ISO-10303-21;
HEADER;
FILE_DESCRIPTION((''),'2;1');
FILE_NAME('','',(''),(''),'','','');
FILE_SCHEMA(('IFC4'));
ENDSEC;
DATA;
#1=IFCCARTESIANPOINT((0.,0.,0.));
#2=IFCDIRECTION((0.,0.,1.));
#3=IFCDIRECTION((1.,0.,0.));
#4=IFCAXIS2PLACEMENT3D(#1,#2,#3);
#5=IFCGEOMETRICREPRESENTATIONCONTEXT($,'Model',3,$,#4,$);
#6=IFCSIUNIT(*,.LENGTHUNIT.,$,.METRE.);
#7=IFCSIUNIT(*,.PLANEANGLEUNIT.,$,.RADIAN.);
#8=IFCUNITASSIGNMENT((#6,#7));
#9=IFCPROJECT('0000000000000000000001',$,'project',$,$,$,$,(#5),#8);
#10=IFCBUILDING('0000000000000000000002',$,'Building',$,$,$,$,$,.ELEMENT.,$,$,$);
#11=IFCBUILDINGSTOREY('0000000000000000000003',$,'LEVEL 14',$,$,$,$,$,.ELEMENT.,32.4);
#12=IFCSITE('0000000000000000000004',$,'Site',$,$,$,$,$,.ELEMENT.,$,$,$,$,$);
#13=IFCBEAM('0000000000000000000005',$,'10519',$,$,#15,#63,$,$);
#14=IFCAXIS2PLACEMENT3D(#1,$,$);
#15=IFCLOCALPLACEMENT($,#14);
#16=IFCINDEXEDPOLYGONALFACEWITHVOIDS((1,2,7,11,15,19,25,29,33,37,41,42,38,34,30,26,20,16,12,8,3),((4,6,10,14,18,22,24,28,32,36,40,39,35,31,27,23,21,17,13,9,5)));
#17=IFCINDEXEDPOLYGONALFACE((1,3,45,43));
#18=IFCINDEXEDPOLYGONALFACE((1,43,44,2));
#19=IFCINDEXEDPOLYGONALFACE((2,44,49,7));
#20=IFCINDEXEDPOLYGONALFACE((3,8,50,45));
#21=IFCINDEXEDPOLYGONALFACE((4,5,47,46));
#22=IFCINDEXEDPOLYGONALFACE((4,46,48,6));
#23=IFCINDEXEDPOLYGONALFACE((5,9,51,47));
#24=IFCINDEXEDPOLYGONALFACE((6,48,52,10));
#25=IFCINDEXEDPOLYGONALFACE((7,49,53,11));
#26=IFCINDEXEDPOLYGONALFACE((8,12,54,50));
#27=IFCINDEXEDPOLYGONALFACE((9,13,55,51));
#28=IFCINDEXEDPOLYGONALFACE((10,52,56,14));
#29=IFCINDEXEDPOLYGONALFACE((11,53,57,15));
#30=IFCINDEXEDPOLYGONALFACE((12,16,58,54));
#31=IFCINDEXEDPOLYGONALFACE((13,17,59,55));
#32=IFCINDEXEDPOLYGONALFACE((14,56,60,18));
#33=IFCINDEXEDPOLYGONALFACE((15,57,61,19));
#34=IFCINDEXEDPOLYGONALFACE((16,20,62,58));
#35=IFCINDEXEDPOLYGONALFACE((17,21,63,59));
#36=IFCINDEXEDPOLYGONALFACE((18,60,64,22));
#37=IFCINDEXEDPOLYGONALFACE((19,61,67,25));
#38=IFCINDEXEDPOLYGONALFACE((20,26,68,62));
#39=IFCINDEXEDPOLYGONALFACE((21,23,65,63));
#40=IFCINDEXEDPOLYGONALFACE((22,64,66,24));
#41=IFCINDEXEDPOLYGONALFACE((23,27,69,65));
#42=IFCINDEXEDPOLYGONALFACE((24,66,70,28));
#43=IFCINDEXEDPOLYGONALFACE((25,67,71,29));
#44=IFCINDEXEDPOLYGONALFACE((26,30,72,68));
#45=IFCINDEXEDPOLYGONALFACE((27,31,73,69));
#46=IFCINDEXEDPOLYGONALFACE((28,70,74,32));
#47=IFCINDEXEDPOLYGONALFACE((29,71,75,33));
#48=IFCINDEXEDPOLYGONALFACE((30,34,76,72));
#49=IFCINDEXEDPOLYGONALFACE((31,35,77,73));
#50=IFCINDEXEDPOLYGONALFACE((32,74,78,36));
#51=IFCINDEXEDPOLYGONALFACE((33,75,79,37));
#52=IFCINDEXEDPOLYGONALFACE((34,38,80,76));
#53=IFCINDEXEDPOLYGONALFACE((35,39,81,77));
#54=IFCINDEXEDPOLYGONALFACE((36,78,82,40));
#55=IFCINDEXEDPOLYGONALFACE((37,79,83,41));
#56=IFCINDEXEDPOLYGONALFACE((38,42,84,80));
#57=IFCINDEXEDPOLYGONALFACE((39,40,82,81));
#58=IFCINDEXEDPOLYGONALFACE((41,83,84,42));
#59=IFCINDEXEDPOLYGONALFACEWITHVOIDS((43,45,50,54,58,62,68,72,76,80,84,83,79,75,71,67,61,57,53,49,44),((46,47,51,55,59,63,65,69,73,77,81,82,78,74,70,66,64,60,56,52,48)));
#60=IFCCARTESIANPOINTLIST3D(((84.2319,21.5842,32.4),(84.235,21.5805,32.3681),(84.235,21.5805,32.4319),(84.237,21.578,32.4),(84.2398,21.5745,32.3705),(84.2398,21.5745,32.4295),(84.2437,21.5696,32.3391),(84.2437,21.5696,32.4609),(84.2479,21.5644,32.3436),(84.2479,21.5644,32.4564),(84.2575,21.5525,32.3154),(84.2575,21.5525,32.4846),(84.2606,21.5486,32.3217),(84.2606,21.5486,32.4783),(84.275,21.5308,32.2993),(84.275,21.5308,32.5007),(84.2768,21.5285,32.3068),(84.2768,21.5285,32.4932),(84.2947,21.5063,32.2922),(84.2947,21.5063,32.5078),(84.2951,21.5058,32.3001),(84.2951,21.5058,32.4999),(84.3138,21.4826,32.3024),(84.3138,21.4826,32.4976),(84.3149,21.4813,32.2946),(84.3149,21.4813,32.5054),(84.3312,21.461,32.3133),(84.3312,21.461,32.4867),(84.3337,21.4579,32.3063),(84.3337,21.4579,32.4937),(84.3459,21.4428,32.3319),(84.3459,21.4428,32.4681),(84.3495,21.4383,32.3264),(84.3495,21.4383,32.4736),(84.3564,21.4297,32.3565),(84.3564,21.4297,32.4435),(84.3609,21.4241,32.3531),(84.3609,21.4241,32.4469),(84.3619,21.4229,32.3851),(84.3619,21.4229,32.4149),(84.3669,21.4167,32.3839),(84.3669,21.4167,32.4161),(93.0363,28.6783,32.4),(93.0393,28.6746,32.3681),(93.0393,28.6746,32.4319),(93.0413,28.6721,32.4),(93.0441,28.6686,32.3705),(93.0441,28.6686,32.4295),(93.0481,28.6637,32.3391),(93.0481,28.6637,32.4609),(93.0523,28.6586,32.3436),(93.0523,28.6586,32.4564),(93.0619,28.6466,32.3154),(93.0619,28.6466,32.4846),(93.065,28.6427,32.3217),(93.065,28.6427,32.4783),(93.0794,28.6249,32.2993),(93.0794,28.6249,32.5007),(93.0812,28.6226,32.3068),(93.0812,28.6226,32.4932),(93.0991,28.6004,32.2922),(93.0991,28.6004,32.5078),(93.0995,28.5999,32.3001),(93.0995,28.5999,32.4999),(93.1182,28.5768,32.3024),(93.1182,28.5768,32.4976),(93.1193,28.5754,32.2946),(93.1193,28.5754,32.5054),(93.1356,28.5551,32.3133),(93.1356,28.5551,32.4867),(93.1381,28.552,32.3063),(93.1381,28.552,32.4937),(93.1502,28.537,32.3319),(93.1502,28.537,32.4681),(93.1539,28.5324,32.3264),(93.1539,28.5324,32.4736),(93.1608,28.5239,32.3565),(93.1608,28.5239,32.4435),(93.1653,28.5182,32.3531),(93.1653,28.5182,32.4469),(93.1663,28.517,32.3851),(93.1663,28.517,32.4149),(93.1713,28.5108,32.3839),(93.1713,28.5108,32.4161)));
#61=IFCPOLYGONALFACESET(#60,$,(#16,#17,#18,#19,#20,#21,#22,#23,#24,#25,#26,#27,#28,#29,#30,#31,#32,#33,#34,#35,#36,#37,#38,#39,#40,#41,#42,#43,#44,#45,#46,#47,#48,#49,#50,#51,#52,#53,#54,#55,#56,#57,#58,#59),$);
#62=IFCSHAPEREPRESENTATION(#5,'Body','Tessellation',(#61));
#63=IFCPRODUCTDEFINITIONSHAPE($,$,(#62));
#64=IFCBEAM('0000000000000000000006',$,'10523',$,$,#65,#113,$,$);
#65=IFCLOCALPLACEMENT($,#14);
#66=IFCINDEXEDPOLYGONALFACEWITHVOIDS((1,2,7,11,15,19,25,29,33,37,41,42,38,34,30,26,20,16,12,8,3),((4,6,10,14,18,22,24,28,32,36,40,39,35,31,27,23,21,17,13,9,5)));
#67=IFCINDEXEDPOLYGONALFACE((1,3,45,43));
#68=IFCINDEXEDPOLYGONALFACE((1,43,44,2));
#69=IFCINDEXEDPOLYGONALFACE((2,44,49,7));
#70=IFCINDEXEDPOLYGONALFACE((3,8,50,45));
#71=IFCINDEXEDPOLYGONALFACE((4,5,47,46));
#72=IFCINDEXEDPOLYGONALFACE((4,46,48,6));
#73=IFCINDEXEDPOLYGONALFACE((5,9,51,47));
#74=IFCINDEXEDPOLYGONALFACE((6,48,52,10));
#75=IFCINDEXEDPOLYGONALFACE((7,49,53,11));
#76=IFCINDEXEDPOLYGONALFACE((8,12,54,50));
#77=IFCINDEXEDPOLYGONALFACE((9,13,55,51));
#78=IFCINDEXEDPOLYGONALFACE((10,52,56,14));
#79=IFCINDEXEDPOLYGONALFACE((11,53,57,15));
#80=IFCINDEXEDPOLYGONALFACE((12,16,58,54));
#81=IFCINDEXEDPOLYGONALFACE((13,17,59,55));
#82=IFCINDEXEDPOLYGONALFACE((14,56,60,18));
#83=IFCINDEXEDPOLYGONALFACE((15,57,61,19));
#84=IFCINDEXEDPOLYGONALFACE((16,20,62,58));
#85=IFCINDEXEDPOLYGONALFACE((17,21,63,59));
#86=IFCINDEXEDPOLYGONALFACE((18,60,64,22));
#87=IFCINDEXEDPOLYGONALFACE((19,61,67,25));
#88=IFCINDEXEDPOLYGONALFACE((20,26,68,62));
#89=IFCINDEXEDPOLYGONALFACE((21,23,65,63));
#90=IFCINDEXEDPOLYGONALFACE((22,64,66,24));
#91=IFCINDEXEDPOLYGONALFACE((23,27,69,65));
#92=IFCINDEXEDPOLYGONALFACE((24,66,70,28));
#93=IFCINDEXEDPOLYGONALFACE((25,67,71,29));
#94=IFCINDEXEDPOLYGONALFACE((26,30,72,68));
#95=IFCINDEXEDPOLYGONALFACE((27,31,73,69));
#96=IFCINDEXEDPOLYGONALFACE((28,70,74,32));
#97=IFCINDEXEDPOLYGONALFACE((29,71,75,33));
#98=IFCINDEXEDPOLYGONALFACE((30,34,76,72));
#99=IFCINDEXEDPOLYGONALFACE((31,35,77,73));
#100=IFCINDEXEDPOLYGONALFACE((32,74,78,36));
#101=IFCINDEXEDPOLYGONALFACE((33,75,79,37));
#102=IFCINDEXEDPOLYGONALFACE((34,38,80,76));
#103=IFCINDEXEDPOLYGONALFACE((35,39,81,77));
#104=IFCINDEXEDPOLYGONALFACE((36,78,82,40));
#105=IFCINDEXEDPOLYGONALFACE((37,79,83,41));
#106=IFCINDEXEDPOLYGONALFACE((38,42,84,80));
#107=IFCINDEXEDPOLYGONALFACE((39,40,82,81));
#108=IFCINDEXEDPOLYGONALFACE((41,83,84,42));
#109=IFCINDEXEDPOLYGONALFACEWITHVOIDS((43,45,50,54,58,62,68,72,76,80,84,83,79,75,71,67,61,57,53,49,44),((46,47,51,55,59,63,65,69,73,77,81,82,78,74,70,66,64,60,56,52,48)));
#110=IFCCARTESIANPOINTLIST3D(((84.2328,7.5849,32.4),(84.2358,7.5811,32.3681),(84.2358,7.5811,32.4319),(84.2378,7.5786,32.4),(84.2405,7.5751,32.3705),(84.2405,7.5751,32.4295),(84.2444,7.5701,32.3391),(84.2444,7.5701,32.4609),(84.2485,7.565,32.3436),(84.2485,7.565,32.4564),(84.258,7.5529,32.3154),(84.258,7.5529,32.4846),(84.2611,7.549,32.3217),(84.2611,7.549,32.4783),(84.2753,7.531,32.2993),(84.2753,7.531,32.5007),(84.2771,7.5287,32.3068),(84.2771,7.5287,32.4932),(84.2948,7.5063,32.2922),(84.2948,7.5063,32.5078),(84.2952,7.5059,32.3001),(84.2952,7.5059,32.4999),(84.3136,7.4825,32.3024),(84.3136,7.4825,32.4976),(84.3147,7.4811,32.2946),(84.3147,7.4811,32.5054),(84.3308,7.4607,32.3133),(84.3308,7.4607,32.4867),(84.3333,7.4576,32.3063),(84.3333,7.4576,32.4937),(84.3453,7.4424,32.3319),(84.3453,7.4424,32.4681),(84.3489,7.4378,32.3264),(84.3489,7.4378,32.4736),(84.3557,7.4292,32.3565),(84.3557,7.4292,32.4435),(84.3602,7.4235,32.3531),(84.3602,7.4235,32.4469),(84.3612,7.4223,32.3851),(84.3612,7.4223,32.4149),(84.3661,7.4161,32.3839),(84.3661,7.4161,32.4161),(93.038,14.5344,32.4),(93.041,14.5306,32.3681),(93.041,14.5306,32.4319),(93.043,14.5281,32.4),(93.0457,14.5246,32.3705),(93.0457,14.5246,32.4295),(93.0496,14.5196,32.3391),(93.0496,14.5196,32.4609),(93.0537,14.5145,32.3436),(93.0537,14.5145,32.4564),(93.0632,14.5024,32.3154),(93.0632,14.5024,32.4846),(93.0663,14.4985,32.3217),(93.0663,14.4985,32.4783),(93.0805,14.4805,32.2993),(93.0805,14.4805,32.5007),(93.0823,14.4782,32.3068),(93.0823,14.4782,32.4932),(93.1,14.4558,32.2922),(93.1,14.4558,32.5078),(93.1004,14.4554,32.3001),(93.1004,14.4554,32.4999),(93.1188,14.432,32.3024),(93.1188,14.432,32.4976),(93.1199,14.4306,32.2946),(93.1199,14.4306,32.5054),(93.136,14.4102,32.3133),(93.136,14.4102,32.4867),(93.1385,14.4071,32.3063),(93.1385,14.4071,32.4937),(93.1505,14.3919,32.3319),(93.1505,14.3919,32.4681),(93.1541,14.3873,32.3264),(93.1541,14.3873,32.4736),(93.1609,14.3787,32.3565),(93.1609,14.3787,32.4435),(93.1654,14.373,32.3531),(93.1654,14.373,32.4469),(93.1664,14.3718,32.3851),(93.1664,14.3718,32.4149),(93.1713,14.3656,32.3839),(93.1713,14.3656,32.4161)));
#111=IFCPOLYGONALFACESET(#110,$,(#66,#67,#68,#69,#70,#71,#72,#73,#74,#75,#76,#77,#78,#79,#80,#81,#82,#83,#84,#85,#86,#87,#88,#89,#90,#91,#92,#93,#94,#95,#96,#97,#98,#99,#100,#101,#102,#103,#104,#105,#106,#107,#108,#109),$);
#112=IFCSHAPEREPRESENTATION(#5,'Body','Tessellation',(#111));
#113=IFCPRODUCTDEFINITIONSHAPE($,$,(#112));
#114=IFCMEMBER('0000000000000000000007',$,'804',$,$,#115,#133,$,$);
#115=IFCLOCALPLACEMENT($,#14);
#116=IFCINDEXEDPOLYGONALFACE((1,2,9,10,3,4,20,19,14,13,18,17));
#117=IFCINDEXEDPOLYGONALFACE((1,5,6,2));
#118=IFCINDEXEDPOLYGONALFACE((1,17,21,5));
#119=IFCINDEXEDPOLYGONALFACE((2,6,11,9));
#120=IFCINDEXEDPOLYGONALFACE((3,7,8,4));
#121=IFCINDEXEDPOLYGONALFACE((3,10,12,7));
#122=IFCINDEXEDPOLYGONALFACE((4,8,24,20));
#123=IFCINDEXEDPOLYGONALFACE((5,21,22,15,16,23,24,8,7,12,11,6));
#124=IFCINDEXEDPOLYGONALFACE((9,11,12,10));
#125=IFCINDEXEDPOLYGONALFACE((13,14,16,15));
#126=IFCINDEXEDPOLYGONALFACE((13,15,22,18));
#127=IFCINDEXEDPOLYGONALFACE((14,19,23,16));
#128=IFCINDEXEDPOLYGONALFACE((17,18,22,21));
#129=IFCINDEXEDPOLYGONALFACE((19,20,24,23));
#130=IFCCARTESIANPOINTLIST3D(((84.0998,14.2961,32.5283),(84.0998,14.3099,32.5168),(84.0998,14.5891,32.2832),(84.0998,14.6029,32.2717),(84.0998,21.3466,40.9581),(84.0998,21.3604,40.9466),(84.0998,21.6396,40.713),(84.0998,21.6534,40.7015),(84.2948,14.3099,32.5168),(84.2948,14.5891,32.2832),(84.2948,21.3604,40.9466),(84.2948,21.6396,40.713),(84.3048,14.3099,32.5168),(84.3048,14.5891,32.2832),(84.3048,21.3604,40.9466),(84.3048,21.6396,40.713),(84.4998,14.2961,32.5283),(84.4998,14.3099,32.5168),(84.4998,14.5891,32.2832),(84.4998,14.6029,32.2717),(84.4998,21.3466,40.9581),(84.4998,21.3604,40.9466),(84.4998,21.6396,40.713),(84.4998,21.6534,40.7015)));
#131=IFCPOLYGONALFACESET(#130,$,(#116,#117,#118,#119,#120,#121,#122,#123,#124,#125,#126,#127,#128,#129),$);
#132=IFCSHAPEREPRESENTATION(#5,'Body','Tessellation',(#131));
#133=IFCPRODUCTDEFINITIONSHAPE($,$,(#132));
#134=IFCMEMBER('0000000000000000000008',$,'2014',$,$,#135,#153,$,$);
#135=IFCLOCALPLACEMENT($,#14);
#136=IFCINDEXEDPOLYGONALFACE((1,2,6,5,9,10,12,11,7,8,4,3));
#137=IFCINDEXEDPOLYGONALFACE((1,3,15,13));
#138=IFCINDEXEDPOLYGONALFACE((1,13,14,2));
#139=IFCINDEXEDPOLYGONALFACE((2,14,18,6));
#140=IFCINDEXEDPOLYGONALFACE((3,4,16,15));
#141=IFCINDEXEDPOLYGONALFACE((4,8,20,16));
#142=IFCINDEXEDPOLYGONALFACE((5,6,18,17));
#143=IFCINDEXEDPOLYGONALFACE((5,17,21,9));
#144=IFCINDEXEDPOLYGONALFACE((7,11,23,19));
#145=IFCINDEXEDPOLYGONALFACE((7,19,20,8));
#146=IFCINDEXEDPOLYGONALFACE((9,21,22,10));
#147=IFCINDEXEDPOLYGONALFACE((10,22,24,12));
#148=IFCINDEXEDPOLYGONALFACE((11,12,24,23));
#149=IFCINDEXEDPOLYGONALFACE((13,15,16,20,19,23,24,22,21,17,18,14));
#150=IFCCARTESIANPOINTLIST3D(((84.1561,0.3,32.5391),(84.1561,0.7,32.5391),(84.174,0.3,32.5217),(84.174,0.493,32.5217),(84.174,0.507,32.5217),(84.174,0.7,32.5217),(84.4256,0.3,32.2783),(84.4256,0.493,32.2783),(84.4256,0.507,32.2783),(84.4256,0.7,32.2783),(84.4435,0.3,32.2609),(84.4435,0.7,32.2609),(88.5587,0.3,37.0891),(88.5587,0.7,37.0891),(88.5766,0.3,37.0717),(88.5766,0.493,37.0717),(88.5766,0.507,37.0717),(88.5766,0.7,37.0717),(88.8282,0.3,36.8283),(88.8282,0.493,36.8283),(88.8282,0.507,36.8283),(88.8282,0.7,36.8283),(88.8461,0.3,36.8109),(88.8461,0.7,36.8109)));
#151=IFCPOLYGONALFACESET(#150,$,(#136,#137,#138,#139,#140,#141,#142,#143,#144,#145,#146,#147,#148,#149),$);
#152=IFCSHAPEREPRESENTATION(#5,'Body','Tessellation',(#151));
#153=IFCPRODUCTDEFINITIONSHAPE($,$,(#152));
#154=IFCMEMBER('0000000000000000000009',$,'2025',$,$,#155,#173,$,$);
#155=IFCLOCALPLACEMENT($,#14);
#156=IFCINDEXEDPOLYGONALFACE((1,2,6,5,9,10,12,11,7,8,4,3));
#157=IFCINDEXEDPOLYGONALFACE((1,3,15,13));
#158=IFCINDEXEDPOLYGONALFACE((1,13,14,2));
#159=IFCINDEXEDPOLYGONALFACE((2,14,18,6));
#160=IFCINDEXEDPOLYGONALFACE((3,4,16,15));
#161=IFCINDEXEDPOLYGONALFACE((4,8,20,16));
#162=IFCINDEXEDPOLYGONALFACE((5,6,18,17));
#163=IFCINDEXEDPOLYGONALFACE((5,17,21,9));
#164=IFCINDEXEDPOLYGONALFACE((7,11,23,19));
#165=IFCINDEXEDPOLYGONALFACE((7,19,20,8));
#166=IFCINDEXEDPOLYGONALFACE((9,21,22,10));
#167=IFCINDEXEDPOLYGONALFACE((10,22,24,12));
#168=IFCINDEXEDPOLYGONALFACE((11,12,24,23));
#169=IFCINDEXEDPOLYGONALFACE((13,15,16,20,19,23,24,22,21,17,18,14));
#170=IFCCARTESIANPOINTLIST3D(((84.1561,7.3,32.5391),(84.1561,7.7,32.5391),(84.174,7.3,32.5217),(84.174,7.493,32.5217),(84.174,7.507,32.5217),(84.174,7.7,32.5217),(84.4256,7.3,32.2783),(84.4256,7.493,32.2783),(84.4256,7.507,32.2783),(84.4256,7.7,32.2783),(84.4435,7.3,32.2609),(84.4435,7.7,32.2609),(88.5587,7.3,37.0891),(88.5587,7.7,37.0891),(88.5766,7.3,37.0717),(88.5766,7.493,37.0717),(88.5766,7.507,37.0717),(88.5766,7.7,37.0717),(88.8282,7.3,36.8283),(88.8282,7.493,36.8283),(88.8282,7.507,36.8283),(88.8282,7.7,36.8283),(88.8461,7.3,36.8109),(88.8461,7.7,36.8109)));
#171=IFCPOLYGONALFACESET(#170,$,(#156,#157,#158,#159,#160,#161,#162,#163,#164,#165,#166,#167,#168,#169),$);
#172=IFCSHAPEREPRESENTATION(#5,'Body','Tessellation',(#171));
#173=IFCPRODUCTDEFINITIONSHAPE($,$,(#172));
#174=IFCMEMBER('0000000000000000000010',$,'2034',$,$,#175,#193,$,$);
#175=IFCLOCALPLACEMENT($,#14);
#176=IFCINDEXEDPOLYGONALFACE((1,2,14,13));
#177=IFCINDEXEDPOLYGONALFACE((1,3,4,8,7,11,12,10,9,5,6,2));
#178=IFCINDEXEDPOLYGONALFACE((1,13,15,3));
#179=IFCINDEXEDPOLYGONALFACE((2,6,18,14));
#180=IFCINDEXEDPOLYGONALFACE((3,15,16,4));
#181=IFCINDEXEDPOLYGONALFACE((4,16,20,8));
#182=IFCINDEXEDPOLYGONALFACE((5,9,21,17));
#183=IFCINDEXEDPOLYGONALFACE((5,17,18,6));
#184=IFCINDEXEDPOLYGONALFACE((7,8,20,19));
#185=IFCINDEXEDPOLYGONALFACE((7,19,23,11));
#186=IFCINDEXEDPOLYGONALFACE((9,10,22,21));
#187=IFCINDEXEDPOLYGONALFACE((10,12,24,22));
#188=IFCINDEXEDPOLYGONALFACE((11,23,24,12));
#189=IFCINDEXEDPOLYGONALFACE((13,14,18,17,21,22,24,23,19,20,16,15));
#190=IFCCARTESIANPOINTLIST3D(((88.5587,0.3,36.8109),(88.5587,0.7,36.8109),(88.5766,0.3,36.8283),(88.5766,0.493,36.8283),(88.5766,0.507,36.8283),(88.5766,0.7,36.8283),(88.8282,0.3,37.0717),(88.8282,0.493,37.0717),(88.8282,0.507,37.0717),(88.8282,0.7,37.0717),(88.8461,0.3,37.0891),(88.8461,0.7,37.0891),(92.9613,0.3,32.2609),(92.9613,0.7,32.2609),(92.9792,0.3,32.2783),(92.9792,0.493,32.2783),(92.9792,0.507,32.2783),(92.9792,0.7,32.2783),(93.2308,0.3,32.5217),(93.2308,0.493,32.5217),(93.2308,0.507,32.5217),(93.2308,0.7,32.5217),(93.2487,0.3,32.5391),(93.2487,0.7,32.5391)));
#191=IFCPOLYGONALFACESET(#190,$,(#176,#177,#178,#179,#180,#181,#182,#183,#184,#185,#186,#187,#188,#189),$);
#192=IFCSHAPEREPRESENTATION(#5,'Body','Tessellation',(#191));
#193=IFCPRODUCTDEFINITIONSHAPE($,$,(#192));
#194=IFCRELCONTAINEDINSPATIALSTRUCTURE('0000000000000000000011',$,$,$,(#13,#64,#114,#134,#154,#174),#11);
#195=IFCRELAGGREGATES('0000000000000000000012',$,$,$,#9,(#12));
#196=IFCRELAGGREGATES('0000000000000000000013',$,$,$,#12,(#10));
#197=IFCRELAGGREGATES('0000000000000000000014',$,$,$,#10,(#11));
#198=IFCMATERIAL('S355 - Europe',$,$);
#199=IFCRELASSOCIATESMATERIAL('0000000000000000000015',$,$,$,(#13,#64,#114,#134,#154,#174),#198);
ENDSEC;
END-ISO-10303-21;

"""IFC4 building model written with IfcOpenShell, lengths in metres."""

from ifc_helpers import new_model, si_unit, frame, origin_with_axes, origin_2d_with_axis, place, context, project, spatial, hollow_circle, i_section, extrude, material, material_profile, profile_set, profile_usage, element, save


model = new_model("IFC4")

# Units and contexts
model_context = context("Model", 3, world=origin_with_axes())
ifc_project = project(units=[si_unit("LENGTHUNIT", "METRE"), si_unit("PLANEANGLEUNIT", "RADIAN")], contexts=[model_context])

# Site, building, storey
site = spatial("IfcSite", under=ifc_project, Name="Site", CompositionType="ELEMENT")
building = spatial("IfcBuilding", under=site, Name="Building", CompositionType="ELEMENT")
storey = spatial("IfcBuildingStorey", under=building, Name="LEVEL 14", CompositionType="ELEMENT", Elevation=32.4)

# Shared definitions
ifc_material = material(Name="S355 - Europe")

# Beams
ifc_material_profile_1 = material_profile(ifc_material, hollow_circle(Radius=0.1081, WallThickness=0.008, at=origin_2d_with_axis()))
ifc_profile_set_1 = profile_set([ifc_material_profile_1])
ifc_profile_usage_1 = profile_usage(ifc_profile_set_1, cardinal=10)
beam_1_placement = place(None, frame((84.2998, 21.5, 32.4), z_axis=(0.77868, 0.627421, 0.0), x_axis=(-0.627421, 0.77868, 0.0)))
element("IfcBeam", 1, at=beam_1_placement, inside=storey, material=ifc_profile_usage_1, Name="10519", context=model_context, shape_type="SweptSolid", body=[
    extrude(hollow_circle(Radius=0.1081, WallThickness=0.008, at=origin_2d_with_axis()), origin_with_axes(), (0.0, 0.0, 1.0), 11.3068),
])
ifc_material_profile_2 = material_profile(ifc_material, hollow_circle(Radius=0.1081, WallThickness=0.008, at=origin_2d_with_axis()))
ifc_profile_set_2 = profile_set([ifc_material_profile_2])
ifc_profile_usage_2 = profile_usage(ifc_profile_set_2, cardinal=10)
beam_2_placement = place(None, frame((84.2998, 7.5, 32.4), z_axis=(0.784968, 0.619536, 0.0), x_axis=(-0.618824, 0.78553, 0.0)))
element("IfcBeam", 2, at=beam_2_placement, inside=storey, material=ifc_profile_usage_2, Name="10523", context=model_context, shape_type="SweptSolid", body=[
    extrude(hollow_circle(Radius=0.1081, WallThickness=0.008, at=origin_2d_with_axis()), origin_with_axes(), (0.0, 0.0, 1.0), 11.2173),
])

# Members
ifc_material_profile_3 = material_profile(ifc_material, i_section(OverallWidth=0.4, OverallDepth=0.4, WebThickness=0.01, FlangeThickness=0.018, at=origin_2d_with_axis()))
ifc_profile_set_3 = profile_set([ifc_material_profile_3])
ifc_profile_usage_3 = profile_usage(ifc_profile_set_3, cardinal=10)
member_1_placement = place(None, frame((84.2998, 14.4495, 32.4), z_axis=(0.0, 0.641562, 0.767071), x_axis=(-1.0, 0.0, 0.0)))
element("IfcMember", 3, at=member_1_placement, inside=storey, material=ifc_profile_usage_3, Name="804", context=model_context, shape_type="SweptSolid", body=[
    extrude(i_section(OverallWidth=0.4, OverallDepth=0.4, WebThickness=0.01, FlangeThickness=0.018, at=origin_2d_with_axis()), origin_with_axes(), (0.0, 0.0, 1.0), 10.9896),
])
ifc_material_profile_4 = material_profile(ifc_material, i_section(OverallWidth=0.4, OverallDepth=0.4, WebThickness=0.014, FlangeThickness=0.025, at=origin_2d_with_axis()))
ifc_profile_set_4 = profile_set([ifc_material_profile_4])
ifc_profile_usage_4 = profile_usage(ifc_profile_set_4, cardinal=10)
member_2_placement = place(None, frame((84.2998, 0.5, 32.4), z_axis=(0.69537, 0.0, 0.718652), x_axis=(0.0, 1.0, 0.0)))
element("IfcMember", 4, at=member_2_placement, inside=storey, material=ifc_profile_usage_4, Name="2014", context=model_context, shape_type="SweptSolid", body=[
    extrude(i_section(OverallWidth=0.4, OverallDepth=0.4, WebThickness=0.014, FlangeThickness=0.025, at=origin_2d_with_axis()), origin_with_axes(), (0.0, 0.0, 1.0), 6.3313),
])
ifc_material_profile_5 = material_profile(ifc_material, i_section(OverallWidth=0.4, OverallDepth=0.4, WebThickness=0.014, FlangeThickness=0.025, at=origin_2d_with_axis()))
ifc_profile_set_5 = profile_set([ifc_material_profile_5])
ifc_profile_usage_5 = profile_usage(ifc_profile_set_5, cardinal=10)
member_3_placement = place(None, frame((84.2998, 7.5, 32.4), z_axis=(0.69537, 0.0, 0.718652), x_axis=(0.0, 1.0, 0.0)))
element("IfcMember", 5, at=member_3_placement, inside=storey, material=ifc_profile_usage_5, Name="2025", context=model_context, shape_type="SweptSolid", body=[
    extrude(i_section(OverallWidth=0.4, OverallDepth=0.4, WebThickness=0.014, FlangeThickness=0.025, at=origin_2d_with_axis()), origin_with_axes(), (0.0, 0.0, 1.0), 6.3313),
])
ifc_material_profile_6 = material_profile(ifc_material, i_section(OverallWidth=0.4, OverallDepth=0.4, WebThickness=0.014, FlangeThickness=0.025, at=origin_2d_with_axis()))
ifc_profile_set_6 = profile_set([ifc_material_profile_6])
ifc_profile_usage_6 = profile_usage(ifc_profile_set_6, cardinal=10)
member_4_placement = place(None, frame((88.7024, 0.5, 36.95), z_axis=(0.69537, 0.0, -0.718652), x_axis=(0.0, 1.0, 0.0)))
element("IfcMember", 6, at=member_4_placement, inside=storey, material=ifc_profile_usage_6, Name="2034", context=model_context, shape_type="SweptSolid", body=[
    extrude(i_section(OverallWidth=0.4, OverallDepth=0.4, WebThickness=0.014, FlangeThickness=0.025, at=origin_2d_with_axis()), origin_with_axes(), (0.0, 0.0, 1.0), 6.3313),
])

save(model, "model.ifc")
